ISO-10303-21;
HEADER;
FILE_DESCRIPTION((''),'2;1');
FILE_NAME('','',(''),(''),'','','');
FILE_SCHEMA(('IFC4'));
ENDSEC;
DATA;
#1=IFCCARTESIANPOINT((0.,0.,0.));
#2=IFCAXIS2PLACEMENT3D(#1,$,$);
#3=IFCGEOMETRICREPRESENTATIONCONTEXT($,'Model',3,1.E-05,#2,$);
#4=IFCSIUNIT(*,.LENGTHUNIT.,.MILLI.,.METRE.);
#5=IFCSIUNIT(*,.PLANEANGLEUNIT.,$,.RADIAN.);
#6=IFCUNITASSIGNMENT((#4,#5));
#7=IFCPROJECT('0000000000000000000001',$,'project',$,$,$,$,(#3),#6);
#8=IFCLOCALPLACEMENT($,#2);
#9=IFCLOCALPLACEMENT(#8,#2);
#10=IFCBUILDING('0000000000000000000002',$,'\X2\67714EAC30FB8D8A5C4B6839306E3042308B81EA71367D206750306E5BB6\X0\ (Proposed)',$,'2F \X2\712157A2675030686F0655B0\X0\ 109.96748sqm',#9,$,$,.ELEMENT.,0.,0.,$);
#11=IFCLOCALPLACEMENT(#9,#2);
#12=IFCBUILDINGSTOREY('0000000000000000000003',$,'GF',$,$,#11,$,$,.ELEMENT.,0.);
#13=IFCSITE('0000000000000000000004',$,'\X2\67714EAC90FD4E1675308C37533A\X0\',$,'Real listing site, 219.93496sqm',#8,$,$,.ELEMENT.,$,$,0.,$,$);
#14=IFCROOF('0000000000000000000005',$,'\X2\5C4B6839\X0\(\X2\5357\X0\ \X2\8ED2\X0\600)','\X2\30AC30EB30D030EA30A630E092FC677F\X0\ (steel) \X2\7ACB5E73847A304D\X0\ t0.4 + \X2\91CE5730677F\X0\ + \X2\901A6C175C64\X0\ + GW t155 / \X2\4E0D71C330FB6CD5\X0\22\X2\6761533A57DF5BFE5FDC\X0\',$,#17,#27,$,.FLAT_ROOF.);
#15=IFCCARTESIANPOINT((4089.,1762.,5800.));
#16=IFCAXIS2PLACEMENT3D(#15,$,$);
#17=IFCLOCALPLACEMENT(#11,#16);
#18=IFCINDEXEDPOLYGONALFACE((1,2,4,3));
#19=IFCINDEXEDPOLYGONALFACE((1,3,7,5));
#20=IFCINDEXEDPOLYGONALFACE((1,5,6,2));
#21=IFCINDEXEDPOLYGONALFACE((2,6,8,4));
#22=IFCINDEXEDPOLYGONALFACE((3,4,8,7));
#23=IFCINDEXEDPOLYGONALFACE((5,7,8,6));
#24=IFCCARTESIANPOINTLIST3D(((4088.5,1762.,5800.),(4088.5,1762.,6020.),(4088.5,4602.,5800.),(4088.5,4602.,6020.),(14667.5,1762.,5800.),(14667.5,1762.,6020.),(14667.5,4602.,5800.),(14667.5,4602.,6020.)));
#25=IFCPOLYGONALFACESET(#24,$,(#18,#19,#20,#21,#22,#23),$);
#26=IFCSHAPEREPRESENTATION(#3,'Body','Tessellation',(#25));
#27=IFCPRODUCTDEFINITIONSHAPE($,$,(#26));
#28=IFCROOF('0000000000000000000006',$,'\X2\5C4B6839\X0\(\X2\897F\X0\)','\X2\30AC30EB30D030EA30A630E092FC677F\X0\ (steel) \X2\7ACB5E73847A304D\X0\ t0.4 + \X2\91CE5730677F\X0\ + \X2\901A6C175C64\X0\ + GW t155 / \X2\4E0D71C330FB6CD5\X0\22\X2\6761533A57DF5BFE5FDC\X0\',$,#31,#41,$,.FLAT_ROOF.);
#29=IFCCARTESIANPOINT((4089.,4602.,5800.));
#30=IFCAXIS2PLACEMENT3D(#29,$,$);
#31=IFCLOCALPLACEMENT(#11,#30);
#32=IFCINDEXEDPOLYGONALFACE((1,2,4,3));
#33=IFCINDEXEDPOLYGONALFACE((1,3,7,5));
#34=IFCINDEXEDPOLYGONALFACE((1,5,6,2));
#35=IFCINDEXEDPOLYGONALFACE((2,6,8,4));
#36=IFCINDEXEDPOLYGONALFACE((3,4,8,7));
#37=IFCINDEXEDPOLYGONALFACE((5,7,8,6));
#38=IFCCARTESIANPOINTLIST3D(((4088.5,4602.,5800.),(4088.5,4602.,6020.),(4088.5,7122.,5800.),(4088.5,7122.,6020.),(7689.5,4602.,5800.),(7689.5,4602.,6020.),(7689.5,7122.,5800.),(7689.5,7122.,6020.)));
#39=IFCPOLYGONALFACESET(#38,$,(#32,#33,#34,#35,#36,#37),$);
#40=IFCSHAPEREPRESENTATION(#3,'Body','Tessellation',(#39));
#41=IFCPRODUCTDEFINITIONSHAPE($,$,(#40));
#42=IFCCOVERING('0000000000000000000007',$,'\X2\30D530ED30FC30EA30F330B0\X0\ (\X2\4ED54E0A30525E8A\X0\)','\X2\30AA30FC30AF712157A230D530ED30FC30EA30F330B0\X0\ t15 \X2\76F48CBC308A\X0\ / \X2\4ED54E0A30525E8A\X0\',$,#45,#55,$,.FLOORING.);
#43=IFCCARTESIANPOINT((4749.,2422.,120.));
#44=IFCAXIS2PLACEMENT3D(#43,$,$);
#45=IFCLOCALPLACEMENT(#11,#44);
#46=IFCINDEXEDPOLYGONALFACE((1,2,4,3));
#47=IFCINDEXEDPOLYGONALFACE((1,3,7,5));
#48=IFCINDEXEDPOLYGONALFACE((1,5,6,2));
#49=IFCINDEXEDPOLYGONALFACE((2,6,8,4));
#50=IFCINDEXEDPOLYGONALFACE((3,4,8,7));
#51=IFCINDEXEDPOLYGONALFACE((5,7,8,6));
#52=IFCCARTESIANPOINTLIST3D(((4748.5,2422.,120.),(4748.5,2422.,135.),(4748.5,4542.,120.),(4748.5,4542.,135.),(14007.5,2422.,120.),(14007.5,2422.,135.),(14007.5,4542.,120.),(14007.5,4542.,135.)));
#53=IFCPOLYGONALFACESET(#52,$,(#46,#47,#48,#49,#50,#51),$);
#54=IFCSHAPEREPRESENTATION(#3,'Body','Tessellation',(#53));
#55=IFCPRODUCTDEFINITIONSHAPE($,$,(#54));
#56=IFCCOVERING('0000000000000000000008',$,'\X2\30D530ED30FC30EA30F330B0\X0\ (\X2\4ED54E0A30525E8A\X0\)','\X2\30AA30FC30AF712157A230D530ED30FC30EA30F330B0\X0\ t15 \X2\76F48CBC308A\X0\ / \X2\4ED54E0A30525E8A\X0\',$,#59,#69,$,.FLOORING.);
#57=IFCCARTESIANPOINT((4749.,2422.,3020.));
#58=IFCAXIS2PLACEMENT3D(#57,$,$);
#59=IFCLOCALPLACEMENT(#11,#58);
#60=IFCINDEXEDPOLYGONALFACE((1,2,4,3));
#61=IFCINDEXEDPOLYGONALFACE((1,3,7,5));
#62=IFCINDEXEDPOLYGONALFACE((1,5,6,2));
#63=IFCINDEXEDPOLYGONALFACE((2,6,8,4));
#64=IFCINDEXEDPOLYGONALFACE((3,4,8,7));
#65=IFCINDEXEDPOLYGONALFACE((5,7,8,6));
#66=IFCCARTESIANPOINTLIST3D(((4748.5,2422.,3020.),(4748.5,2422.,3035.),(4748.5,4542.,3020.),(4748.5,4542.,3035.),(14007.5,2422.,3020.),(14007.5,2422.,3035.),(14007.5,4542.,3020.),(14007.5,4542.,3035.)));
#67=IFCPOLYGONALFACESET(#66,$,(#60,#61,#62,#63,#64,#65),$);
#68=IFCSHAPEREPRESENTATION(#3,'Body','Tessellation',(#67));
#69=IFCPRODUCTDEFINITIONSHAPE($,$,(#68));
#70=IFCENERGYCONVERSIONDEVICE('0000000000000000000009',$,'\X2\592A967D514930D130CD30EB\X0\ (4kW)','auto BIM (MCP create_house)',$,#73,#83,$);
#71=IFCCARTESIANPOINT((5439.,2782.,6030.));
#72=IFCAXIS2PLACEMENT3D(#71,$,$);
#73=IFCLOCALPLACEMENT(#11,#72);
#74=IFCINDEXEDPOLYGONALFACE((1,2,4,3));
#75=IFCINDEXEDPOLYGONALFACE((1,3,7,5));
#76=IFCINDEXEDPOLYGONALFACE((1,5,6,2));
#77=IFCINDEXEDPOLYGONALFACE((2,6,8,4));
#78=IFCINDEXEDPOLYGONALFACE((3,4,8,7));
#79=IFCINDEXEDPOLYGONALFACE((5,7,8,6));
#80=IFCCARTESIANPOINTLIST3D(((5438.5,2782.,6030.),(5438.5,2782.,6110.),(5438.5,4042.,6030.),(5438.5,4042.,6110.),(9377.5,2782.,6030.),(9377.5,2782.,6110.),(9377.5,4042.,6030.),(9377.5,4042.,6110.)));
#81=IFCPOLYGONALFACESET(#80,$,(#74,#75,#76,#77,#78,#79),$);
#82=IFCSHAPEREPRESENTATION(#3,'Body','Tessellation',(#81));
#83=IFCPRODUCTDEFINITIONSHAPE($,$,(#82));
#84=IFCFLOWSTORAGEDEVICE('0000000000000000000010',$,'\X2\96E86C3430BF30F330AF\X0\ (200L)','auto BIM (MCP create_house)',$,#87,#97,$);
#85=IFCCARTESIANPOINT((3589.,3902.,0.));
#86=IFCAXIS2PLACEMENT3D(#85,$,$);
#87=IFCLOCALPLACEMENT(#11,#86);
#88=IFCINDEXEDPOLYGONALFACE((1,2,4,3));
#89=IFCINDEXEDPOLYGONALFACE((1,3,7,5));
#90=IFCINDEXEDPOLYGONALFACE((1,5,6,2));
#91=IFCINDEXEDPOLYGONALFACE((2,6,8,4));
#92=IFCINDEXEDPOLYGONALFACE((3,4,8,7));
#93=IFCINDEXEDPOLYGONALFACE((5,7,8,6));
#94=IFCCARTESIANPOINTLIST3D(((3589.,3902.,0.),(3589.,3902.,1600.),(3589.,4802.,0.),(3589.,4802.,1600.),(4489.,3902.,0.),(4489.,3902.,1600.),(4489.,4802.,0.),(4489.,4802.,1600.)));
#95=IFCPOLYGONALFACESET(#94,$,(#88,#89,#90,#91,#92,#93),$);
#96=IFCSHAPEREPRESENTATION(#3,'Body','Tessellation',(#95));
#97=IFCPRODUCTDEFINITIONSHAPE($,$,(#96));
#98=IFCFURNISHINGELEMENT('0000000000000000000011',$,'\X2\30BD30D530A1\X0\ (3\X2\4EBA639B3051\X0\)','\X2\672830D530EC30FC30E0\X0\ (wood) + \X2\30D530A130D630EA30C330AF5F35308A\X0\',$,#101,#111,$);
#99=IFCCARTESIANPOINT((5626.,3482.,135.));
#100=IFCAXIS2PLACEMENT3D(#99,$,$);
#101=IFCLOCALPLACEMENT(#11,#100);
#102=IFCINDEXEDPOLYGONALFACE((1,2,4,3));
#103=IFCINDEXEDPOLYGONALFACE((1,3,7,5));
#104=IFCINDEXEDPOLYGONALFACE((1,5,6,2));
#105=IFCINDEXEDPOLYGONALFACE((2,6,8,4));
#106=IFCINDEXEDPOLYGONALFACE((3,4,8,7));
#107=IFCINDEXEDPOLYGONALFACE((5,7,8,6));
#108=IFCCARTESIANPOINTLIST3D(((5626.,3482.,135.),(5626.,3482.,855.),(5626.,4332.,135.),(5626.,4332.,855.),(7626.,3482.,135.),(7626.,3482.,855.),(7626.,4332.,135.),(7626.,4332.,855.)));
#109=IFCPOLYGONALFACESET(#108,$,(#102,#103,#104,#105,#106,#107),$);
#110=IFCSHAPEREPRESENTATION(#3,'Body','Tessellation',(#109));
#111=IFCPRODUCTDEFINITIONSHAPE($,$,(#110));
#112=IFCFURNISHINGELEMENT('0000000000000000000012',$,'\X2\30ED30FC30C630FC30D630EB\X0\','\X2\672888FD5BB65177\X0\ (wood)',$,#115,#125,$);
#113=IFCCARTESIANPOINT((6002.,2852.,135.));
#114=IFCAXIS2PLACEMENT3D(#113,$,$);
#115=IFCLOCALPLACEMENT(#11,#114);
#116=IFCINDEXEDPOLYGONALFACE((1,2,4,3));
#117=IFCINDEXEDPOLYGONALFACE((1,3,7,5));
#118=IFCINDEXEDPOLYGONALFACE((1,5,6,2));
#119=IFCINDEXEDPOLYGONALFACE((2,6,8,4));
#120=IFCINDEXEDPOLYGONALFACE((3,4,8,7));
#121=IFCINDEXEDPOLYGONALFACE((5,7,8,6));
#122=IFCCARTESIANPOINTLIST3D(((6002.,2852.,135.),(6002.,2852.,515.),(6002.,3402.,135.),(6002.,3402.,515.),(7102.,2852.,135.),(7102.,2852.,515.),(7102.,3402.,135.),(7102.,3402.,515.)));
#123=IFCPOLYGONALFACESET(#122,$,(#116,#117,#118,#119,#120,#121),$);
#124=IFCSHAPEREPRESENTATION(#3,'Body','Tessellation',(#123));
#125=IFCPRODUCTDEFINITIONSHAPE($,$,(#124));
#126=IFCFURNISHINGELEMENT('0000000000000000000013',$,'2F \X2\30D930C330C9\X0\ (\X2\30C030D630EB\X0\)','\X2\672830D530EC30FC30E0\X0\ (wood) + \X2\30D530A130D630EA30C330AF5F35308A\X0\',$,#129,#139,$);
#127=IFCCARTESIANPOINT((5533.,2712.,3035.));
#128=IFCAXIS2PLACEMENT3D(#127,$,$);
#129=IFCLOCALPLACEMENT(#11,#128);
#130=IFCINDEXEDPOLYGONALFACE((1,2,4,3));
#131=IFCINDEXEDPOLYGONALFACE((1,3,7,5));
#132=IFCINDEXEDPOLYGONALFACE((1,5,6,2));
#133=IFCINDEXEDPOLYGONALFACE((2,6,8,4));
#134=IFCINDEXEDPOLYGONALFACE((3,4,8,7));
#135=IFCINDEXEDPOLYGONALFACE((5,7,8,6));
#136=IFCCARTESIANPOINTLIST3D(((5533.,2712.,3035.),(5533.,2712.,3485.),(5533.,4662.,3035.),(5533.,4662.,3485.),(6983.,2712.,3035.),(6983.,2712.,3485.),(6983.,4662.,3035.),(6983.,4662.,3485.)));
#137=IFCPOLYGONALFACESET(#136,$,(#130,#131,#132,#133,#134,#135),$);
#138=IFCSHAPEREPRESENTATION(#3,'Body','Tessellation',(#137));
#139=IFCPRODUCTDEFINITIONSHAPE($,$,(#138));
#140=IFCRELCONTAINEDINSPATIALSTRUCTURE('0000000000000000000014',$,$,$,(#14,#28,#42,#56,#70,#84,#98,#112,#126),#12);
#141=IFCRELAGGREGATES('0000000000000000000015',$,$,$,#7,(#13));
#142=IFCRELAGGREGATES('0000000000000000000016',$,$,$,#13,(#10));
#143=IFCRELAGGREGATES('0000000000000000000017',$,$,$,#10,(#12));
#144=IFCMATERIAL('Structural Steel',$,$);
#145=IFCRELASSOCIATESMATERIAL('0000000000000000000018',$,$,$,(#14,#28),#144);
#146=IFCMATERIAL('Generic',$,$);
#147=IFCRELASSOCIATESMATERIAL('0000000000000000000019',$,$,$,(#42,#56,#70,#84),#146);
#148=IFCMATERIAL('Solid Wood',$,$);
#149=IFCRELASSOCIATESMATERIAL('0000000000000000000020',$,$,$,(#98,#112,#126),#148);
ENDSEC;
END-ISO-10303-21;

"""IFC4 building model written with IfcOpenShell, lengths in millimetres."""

from ifc_helpers import new_model, si_unit, frame, frame_2d, origin, place, context, project, spatial, rectangle, extrude, material, element, save


model = new_model("IFC4")

# Units and contexts
model_context = context("Model", 3, precision=1e-05, world=origin())
ifc_project = project(units=[si_unit("LENGTHUNIT", "METRE", prefix="MILLI"), si_unit("PLANEANGLEUNIT", "RADIAN")], contexts=[model_context])

# Site, building, storey
site_placement = place(None, origin())
site = spatial("IfcSite", under=ifc_project, at=site_placement, Name="東京都世田谷区", ObjectType="Real listing site, 219.93496sqm", CompositionType="ELEMENT", RefElevation=0.0)
building_placement = place(site_placement, origin())
building = spatial("IfcBuilding", under=site, at=building_placement, Name="東京・越屋根のある自然素材の家 (Proposed)", ObjectType="2F 無垢材と漆喰 109.96748sqm", CompositionType="ELEMENT", ElevationOfRefHeight=0.0, ElevationOfTerrain=0.0)
storey_placement = place(building_placement, origin())
storey = spatial("IfcBuildingStorey", under=building, at=storey_placement, Name="GF", CompositionType="ELEMENT", Elevation=0.0)

# Shared definitions
ifc_material_1 = material(Name="Solid Wood")

# Roofs
ifc_material_2 = material(Name="Structural Steel")
roof_1_placement = place(storey_placement, frame((4089.0, 1762.0, 5800.0)))
element("IfcRoof", 1, at=roof_1_placement, inside=storey, material=ifc_material_2, Name="屋根(南 軒600)", Description="ガルバリウム鋼板 (steel) 立平葺き t0.4 + 野地板 + 通気層 + GW t155 / 不燃・法22条区域対応", PredefinedType="FLAT_ROOF", context=model_context, shape_type="SweptSolid", body=[
    extrude(rectangle(XDim=10579.0, YDim=2840.0, at=frame_2d((5289.0, 1420.0))), frame((4089.0, 1762.0, 5800.0)), (0.0, 0.0, 1.0), 220.0),
])
roof_2_placement = place(storey_placement, frame((4089.0, 4602.0, 5800.0)))
element("IfcRoof", 2, at=roof_2_placement, inside=storey, material=ifc_material_2, Name="屋根(西)", Description="ガルバリウム鋼板 (steel) 立平葺き t0.4 + 野地板 + 通気層 + GW t155 / 不燃・法22条区域対応", PredefinedType="FLAT_ROOF", context=model_context, shape_type="SweptSolid", body=[
    extrude(rectangle(XDim=3601.0, YDim=2520.0, at=frame_2d((1800.0, 1260.0))), frame((4089.0, 4602.0, 5800.0)), (0.0, 0.0, 1.0), 220.0),
])

# Coverings
ifc_material_3 = material(Name="Generic")
covering_1_placement = place(storey_placement, frame((4749.0, 2422.0, 120.0)))
element("IfcCovering", 3, at=covering_1_placement, inside=storey, material=ifc_material_3, Name="フローリング (仕上げ床)", Description="オーク無垢フローリング t15 直貼り / 仕上げ床", PredefinedType="FLOORING", context=model_context, shape_type="SweptSolid", body=[
    extrude(rectangle(XDim=9259.0, YDim=2120.0, at=frame_2d((4629.0, 1060.0))), frame((4749.0, 2422.0, 120.0)), (0.0, 0.0, 1.0), 15.0),
])
covering_2_placement = place(storey_placement, frame((4749.0, 2422.0, 3020.0)))
element("IfcCovering", 4, at=covering_2_placement, inside=storey, material=ifc_material_3, Name="フローリング (仕上げ床)", Description="オーク無垢フローリング t15 直貼り / 仕上げ床", PredefinedType="FLOORING", context=model_context, shape_type="SweptSolid", body=[
    extrude(rectangle(XDim=9259.0, YDim=2120.0, at=frame_2d((4629.0, 1060.0))), frame((4749.0, 2422.0, 3020.0)), (0.0, 0.0, 1.0), 15.0),
])

# Energy conversion device
energy_conversion_device_placement = place(storey_placement, frame((5439.0, 2782.0, 6030.0)))
element("IfcEnergyConversionDevice", 5, at=energy_conversion_device_placement, inside=storey, material=ifc_material_3, Name="太陽光パネル (4kW)", Description="auto BIM (MCP create_house)", context=model_context, shape_type="SweptSolid", body=[
    extrude(rectangle(XDim=3939.0, YDim=1260.0, at=frame_2d((1969.0, 630.0))), frame((5439.0, 2782.0, 6030.0)), (0.0, 0.0, 1.0), 80.0),
])

# Flow storage device
flow_storage_device_placement = place(storey_placement, frame((3589.0, 3902.0, 0.0)))
element("IfcFlowStorageDevice", 6, at=flow_storage_device_placement, inside=storey, material=ifc_material_3, Name="雨水タンク (200L)", Description="auto BIM (MCP create_house)", context=model_context, shape_type="SweptSolid", body=[
    extrude(rectangle(XDim=900.0, YDim=900.0, at=frame_2d((450.0, 450.0))), frame((3589.0, 3902.0, 0.0)), (0.0, 0.0, 1.0), 1600.0),
])

# Furnishing elements
furnishing_1_placement = place(storey_placement, frame((5626.0, 3482.0, 135.0)))
element("IfcFurnishingElement", 7, at=furnishing_1_placement, inside=storey, material=ifc_material_1, Name="ソファ (3人掛け)", Description="木フレーム (wood) + ファブリック張り", context=model_context, shape_type="SweptSolid", body=[
    extrude(rectangle(XDim=2000.0, YDim=850.0, at=frame_2d((1000.0, 425.0))), frame((5626.0, 3482.0, 135.0)), (0.0, 0.0, 1.0), 720.0),
])
furnishing_2_placement = place(storey_placement, frame((6002.0, 2852.0, 135.0)))
element("IfcFurnishingElement", 8, at=furnishing_2_placement, inside=storey, material=ifc_material_1, Name="ローテーブル", Description="木製家具 (wood)", context=model_context, shape_type="SweptSolid", body=[
    extrude(rectangle(XDim=1100.0, YDim=550.0, at=frame_2d((550.0, 275.0))), frame((6002.0, 2852.0, 135.0)), (0.0, 0.0, 1.0), 380.0),
])
furnishing_3_placement = place(storey_placement, frame((5533.0, 2712.0, 3035.0)))
element("IfcFurnishingElement", 9, at=furnishing_3_placement, inside=storey, material=ifc_material_1, Name="2F ベッド (ダブル)", Description="木フレーム (wood) + ファブリック張り", context=model_context, shape_type="SweptSolid", body=[
    extrude(rectangle(XDim=1450.0, YDim=1950.0, at=frame_2d((725.0, 975.0))), frame((5533.0, 2712.0, 3035.0)), (0.0, 0.0, 1.0), 450.0),
])

save(model, "model.ifc")
